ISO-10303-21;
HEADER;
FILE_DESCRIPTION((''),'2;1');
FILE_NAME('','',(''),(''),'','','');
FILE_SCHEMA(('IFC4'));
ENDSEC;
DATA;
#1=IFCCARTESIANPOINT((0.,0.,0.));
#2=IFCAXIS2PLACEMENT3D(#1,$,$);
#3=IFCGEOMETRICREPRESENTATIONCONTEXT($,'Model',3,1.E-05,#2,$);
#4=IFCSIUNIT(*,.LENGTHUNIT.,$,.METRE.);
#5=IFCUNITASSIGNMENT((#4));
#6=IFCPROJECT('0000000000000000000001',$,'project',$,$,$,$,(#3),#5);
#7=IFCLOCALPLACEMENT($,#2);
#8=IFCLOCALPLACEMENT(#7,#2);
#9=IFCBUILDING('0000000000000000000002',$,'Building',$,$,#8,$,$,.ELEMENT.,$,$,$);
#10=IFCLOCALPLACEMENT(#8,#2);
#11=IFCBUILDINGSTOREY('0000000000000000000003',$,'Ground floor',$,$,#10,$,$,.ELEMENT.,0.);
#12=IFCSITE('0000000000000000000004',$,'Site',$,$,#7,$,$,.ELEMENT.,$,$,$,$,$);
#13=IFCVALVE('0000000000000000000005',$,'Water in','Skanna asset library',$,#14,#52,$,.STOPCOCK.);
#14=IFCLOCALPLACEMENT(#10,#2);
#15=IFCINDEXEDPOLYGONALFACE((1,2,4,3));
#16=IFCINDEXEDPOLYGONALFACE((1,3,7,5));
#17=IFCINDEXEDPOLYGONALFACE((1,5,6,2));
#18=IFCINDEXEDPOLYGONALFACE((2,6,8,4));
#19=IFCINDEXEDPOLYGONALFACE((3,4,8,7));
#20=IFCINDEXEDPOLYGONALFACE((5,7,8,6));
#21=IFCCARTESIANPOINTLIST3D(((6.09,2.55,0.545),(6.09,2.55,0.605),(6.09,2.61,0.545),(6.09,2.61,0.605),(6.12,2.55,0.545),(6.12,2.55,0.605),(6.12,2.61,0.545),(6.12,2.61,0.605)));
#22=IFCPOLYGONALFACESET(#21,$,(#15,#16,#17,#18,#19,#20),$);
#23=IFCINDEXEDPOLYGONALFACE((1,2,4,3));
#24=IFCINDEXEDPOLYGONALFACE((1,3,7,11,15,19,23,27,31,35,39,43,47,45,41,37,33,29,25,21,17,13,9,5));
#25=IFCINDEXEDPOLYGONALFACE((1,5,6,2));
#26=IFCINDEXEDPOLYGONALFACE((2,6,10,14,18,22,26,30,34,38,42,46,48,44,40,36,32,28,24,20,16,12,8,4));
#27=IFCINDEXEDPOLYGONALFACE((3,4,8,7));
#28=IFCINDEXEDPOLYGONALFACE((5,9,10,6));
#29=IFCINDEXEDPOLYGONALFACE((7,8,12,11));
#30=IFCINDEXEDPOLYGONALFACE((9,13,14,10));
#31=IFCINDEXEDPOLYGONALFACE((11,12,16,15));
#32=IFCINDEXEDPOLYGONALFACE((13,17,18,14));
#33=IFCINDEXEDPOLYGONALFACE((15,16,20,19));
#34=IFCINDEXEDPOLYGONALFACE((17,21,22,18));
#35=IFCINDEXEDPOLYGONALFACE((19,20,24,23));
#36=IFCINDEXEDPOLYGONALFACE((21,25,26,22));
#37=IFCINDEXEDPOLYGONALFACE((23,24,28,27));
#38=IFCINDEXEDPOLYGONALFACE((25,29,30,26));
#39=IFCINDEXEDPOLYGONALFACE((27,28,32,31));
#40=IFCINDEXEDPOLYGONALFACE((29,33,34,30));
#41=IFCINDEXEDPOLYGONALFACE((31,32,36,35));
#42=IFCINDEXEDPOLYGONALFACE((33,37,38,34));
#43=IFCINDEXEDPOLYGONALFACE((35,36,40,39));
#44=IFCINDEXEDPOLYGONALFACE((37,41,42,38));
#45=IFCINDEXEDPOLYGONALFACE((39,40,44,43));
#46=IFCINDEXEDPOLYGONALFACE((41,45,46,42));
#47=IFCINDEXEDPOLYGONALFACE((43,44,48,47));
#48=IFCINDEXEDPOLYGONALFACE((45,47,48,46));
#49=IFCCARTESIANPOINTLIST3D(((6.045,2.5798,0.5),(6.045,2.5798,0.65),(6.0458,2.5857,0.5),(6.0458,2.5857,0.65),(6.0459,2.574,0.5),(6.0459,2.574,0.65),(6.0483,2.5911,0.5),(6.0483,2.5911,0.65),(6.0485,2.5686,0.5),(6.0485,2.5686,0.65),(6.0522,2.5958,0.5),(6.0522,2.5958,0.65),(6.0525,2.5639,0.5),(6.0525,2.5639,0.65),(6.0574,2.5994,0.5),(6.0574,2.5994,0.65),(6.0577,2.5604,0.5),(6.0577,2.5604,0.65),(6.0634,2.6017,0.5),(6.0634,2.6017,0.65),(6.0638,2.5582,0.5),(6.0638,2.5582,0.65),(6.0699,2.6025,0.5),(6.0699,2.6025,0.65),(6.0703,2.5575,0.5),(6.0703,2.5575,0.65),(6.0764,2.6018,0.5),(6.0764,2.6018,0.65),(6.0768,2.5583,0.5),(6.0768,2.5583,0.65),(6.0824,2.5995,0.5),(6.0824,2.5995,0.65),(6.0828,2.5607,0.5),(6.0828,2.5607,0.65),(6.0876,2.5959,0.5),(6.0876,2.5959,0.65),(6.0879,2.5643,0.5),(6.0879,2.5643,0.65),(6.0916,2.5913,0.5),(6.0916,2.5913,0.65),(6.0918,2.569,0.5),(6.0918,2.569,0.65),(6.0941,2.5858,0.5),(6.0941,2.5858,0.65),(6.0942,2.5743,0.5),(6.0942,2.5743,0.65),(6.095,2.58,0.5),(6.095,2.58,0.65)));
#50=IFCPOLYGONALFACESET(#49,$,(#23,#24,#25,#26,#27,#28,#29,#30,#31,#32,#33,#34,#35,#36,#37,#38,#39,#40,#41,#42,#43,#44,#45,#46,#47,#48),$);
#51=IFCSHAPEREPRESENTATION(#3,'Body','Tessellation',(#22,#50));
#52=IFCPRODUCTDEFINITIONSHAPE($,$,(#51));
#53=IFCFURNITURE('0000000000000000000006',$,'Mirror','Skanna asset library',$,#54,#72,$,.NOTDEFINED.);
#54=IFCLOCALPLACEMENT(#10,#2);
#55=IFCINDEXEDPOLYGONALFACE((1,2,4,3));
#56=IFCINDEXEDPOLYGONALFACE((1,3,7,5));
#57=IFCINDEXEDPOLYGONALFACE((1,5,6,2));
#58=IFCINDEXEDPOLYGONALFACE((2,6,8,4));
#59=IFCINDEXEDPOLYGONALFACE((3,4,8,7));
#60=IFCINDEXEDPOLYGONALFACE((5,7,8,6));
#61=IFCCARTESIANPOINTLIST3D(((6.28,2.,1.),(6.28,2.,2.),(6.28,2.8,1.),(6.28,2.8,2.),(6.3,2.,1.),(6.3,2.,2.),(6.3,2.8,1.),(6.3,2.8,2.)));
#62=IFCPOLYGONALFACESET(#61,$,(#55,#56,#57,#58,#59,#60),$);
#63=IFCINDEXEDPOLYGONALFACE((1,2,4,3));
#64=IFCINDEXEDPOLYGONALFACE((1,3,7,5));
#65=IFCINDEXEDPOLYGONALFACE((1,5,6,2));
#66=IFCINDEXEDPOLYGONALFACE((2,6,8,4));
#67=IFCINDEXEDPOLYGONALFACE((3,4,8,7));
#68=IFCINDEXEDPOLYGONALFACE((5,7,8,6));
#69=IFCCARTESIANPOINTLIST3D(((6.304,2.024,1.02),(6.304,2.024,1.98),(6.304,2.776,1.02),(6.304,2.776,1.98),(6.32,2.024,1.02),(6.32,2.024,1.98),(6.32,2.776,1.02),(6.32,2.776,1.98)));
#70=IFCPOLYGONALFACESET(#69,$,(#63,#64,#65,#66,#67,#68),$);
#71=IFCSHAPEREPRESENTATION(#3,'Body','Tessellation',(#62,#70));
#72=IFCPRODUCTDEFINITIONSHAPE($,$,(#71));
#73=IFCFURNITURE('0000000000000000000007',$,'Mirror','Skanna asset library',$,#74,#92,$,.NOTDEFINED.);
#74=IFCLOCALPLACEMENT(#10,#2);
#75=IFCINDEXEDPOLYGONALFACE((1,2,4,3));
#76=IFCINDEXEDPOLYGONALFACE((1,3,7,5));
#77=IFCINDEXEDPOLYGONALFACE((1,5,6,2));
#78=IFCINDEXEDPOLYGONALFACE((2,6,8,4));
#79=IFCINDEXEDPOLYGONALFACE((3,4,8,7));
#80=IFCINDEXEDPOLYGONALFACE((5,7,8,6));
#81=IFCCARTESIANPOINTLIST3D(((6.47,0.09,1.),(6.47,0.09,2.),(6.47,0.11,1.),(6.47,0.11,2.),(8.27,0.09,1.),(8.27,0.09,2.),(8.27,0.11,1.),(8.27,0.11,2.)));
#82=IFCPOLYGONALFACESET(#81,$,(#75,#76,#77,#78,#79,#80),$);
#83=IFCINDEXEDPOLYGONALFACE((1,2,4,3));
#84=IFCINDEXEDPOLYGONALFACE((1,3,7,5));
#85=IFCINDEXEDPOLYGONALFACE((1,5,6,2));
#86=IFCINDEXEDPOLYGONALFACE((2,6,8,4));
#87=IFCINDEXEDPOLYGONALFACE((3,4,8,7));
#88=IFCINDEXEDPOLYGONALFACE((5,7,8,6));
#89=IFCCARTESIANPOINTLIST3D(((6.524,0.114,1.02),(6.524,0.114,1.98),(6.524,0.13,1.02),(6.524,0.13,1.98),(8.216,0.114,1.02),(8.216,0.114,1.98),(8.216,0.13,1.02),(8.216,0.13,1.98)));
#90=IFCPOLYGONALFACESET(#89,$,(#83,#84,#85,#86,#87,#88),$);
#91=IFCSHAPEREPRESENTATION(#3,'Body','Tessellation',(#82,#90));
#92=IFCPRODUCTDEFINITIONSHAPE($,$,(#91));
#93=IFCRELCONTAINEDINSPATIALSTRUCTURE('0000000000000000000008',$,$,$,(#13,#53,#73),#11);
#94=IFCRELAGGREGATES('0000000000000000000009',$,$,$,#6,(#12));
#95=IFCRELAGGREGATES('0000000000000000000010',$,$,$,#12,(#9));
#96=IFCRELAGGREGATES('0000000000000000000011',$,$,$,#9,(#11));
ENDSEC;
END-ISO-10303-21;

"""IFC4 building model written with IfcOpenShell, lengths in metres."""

from ifc_helpers import new_model, si_unit, frame, frame_2d, origin, origin_2d, place, context, project, spatial, rectangle, ellipse, extrude, element, save


model = new_model("IFC4")

# Units and contexts
model_context = context("Model", 3, precision=1e-05, world=origin())
ifc_project = project(units=[si_unit("LENGTHUNIT", "METRE")], contexts=[model_context])

# Site, building, storey
site_placement = place(None, origin())
site = spatial("IfcSite", under=ifc_project, at=site_placement, Name="Site", CompositionType="ELEMENT")
building_placement = place(site_placement, origin())
building = spatial("IfcBuilding", under=site, at=building_placement, Name="Building", CompositionType="ELEMENT")
storey_placement = place(building_placement, origin())
storey = spatial("IfcBuildingStorey", under=building, at=storey_placement, Name="Ground floor", CompositionType="ELEMENT", Elevation=0.0)

# Valve
for number, where, z_axis, x_axis, name in (
    (1, (6.07, 2.58, 0.5), (0.0, 0.0, 1.0), (0.0, -1.0, 0.0), "Water in"),
):
    element("IfcValve", number, at=place(storey_placement, frame(where, z_axis=z_axis, x_axis=x_axis)), inside=storey, Name=name, Description="Skanna asset library", PredefinedType="STOPCOCK", context=model_context, shape_type="SweptSolid", body=[
        extrude(rectangle(XDim=0.06, YDim=0.03, at=frame_2d((0.0, 0.035))), frame((0.0, 0.0, 0.045)), (0.0, 0.0, 1.0), 0.06),
        extrude(ellipse(SemiAxis1=0.0225, SemiAxis2=0.025, at=origin_2d()), origin(), (0.0, 0.0, 1.0), 0.15),
    ])

# Furniture
furniture_1_placement = place(storey_placement, frame((6.3, 2.4, 1.0), z_axis=(0.0, 0.0, 1.0), x_axis=(0.0, 1.0, 0.0)))
element("IfcFurniture", 2, at=furniture_1_placement, inside=storey, Name="Mirror", Description="Skanna asset library", PredefinedType="NOTDEFINED", context=model_context, shape_type="SweptSolid", body=[
    extrude(rectangle(XDim=0.8, YDim=0.02, at=frame_2d((0.0, 0.01))), origin(), (0.0, 0.0, 1.0), 1.0),
    extrude(rectangle(XDim=0.752, YDim=0.016, at=frame_2d((0.0, -0.012))), frame((0.0, 0.0, 0.02)), (0.0, 0.0, 1.0), 0.96),
])
furniture_2_placement = place(storey_placement, frame((7.37, 0.11, 1.0), z_axis=(0.0, 0.0, 1.0), x_axis=(-1.0, 0.0, 0.0)))
element("IfcFurniture", 3, at=furniture_2_placement, inside=storey, Name="Mirror", Description="Skanna asset library", PredefinedType="NOTDEFINED", context=model_context, shape_type="SweptSolid", body=[
    extrude(rectangle(XDim=1.8, YDim=0.02, at=frame_2d((0.0, 0.01))), origin(), (0.0, 0.0, 1.0), 1.0),
    extrude(rectangle(XDim=1.692, YDim=0.016, at=frame_2d((0.0, -0.012))), frame((0.0, 0.0, 0.02)), (0.0, 0.0, 1.0), 0.96),
])

save(model, "model.ifc")
